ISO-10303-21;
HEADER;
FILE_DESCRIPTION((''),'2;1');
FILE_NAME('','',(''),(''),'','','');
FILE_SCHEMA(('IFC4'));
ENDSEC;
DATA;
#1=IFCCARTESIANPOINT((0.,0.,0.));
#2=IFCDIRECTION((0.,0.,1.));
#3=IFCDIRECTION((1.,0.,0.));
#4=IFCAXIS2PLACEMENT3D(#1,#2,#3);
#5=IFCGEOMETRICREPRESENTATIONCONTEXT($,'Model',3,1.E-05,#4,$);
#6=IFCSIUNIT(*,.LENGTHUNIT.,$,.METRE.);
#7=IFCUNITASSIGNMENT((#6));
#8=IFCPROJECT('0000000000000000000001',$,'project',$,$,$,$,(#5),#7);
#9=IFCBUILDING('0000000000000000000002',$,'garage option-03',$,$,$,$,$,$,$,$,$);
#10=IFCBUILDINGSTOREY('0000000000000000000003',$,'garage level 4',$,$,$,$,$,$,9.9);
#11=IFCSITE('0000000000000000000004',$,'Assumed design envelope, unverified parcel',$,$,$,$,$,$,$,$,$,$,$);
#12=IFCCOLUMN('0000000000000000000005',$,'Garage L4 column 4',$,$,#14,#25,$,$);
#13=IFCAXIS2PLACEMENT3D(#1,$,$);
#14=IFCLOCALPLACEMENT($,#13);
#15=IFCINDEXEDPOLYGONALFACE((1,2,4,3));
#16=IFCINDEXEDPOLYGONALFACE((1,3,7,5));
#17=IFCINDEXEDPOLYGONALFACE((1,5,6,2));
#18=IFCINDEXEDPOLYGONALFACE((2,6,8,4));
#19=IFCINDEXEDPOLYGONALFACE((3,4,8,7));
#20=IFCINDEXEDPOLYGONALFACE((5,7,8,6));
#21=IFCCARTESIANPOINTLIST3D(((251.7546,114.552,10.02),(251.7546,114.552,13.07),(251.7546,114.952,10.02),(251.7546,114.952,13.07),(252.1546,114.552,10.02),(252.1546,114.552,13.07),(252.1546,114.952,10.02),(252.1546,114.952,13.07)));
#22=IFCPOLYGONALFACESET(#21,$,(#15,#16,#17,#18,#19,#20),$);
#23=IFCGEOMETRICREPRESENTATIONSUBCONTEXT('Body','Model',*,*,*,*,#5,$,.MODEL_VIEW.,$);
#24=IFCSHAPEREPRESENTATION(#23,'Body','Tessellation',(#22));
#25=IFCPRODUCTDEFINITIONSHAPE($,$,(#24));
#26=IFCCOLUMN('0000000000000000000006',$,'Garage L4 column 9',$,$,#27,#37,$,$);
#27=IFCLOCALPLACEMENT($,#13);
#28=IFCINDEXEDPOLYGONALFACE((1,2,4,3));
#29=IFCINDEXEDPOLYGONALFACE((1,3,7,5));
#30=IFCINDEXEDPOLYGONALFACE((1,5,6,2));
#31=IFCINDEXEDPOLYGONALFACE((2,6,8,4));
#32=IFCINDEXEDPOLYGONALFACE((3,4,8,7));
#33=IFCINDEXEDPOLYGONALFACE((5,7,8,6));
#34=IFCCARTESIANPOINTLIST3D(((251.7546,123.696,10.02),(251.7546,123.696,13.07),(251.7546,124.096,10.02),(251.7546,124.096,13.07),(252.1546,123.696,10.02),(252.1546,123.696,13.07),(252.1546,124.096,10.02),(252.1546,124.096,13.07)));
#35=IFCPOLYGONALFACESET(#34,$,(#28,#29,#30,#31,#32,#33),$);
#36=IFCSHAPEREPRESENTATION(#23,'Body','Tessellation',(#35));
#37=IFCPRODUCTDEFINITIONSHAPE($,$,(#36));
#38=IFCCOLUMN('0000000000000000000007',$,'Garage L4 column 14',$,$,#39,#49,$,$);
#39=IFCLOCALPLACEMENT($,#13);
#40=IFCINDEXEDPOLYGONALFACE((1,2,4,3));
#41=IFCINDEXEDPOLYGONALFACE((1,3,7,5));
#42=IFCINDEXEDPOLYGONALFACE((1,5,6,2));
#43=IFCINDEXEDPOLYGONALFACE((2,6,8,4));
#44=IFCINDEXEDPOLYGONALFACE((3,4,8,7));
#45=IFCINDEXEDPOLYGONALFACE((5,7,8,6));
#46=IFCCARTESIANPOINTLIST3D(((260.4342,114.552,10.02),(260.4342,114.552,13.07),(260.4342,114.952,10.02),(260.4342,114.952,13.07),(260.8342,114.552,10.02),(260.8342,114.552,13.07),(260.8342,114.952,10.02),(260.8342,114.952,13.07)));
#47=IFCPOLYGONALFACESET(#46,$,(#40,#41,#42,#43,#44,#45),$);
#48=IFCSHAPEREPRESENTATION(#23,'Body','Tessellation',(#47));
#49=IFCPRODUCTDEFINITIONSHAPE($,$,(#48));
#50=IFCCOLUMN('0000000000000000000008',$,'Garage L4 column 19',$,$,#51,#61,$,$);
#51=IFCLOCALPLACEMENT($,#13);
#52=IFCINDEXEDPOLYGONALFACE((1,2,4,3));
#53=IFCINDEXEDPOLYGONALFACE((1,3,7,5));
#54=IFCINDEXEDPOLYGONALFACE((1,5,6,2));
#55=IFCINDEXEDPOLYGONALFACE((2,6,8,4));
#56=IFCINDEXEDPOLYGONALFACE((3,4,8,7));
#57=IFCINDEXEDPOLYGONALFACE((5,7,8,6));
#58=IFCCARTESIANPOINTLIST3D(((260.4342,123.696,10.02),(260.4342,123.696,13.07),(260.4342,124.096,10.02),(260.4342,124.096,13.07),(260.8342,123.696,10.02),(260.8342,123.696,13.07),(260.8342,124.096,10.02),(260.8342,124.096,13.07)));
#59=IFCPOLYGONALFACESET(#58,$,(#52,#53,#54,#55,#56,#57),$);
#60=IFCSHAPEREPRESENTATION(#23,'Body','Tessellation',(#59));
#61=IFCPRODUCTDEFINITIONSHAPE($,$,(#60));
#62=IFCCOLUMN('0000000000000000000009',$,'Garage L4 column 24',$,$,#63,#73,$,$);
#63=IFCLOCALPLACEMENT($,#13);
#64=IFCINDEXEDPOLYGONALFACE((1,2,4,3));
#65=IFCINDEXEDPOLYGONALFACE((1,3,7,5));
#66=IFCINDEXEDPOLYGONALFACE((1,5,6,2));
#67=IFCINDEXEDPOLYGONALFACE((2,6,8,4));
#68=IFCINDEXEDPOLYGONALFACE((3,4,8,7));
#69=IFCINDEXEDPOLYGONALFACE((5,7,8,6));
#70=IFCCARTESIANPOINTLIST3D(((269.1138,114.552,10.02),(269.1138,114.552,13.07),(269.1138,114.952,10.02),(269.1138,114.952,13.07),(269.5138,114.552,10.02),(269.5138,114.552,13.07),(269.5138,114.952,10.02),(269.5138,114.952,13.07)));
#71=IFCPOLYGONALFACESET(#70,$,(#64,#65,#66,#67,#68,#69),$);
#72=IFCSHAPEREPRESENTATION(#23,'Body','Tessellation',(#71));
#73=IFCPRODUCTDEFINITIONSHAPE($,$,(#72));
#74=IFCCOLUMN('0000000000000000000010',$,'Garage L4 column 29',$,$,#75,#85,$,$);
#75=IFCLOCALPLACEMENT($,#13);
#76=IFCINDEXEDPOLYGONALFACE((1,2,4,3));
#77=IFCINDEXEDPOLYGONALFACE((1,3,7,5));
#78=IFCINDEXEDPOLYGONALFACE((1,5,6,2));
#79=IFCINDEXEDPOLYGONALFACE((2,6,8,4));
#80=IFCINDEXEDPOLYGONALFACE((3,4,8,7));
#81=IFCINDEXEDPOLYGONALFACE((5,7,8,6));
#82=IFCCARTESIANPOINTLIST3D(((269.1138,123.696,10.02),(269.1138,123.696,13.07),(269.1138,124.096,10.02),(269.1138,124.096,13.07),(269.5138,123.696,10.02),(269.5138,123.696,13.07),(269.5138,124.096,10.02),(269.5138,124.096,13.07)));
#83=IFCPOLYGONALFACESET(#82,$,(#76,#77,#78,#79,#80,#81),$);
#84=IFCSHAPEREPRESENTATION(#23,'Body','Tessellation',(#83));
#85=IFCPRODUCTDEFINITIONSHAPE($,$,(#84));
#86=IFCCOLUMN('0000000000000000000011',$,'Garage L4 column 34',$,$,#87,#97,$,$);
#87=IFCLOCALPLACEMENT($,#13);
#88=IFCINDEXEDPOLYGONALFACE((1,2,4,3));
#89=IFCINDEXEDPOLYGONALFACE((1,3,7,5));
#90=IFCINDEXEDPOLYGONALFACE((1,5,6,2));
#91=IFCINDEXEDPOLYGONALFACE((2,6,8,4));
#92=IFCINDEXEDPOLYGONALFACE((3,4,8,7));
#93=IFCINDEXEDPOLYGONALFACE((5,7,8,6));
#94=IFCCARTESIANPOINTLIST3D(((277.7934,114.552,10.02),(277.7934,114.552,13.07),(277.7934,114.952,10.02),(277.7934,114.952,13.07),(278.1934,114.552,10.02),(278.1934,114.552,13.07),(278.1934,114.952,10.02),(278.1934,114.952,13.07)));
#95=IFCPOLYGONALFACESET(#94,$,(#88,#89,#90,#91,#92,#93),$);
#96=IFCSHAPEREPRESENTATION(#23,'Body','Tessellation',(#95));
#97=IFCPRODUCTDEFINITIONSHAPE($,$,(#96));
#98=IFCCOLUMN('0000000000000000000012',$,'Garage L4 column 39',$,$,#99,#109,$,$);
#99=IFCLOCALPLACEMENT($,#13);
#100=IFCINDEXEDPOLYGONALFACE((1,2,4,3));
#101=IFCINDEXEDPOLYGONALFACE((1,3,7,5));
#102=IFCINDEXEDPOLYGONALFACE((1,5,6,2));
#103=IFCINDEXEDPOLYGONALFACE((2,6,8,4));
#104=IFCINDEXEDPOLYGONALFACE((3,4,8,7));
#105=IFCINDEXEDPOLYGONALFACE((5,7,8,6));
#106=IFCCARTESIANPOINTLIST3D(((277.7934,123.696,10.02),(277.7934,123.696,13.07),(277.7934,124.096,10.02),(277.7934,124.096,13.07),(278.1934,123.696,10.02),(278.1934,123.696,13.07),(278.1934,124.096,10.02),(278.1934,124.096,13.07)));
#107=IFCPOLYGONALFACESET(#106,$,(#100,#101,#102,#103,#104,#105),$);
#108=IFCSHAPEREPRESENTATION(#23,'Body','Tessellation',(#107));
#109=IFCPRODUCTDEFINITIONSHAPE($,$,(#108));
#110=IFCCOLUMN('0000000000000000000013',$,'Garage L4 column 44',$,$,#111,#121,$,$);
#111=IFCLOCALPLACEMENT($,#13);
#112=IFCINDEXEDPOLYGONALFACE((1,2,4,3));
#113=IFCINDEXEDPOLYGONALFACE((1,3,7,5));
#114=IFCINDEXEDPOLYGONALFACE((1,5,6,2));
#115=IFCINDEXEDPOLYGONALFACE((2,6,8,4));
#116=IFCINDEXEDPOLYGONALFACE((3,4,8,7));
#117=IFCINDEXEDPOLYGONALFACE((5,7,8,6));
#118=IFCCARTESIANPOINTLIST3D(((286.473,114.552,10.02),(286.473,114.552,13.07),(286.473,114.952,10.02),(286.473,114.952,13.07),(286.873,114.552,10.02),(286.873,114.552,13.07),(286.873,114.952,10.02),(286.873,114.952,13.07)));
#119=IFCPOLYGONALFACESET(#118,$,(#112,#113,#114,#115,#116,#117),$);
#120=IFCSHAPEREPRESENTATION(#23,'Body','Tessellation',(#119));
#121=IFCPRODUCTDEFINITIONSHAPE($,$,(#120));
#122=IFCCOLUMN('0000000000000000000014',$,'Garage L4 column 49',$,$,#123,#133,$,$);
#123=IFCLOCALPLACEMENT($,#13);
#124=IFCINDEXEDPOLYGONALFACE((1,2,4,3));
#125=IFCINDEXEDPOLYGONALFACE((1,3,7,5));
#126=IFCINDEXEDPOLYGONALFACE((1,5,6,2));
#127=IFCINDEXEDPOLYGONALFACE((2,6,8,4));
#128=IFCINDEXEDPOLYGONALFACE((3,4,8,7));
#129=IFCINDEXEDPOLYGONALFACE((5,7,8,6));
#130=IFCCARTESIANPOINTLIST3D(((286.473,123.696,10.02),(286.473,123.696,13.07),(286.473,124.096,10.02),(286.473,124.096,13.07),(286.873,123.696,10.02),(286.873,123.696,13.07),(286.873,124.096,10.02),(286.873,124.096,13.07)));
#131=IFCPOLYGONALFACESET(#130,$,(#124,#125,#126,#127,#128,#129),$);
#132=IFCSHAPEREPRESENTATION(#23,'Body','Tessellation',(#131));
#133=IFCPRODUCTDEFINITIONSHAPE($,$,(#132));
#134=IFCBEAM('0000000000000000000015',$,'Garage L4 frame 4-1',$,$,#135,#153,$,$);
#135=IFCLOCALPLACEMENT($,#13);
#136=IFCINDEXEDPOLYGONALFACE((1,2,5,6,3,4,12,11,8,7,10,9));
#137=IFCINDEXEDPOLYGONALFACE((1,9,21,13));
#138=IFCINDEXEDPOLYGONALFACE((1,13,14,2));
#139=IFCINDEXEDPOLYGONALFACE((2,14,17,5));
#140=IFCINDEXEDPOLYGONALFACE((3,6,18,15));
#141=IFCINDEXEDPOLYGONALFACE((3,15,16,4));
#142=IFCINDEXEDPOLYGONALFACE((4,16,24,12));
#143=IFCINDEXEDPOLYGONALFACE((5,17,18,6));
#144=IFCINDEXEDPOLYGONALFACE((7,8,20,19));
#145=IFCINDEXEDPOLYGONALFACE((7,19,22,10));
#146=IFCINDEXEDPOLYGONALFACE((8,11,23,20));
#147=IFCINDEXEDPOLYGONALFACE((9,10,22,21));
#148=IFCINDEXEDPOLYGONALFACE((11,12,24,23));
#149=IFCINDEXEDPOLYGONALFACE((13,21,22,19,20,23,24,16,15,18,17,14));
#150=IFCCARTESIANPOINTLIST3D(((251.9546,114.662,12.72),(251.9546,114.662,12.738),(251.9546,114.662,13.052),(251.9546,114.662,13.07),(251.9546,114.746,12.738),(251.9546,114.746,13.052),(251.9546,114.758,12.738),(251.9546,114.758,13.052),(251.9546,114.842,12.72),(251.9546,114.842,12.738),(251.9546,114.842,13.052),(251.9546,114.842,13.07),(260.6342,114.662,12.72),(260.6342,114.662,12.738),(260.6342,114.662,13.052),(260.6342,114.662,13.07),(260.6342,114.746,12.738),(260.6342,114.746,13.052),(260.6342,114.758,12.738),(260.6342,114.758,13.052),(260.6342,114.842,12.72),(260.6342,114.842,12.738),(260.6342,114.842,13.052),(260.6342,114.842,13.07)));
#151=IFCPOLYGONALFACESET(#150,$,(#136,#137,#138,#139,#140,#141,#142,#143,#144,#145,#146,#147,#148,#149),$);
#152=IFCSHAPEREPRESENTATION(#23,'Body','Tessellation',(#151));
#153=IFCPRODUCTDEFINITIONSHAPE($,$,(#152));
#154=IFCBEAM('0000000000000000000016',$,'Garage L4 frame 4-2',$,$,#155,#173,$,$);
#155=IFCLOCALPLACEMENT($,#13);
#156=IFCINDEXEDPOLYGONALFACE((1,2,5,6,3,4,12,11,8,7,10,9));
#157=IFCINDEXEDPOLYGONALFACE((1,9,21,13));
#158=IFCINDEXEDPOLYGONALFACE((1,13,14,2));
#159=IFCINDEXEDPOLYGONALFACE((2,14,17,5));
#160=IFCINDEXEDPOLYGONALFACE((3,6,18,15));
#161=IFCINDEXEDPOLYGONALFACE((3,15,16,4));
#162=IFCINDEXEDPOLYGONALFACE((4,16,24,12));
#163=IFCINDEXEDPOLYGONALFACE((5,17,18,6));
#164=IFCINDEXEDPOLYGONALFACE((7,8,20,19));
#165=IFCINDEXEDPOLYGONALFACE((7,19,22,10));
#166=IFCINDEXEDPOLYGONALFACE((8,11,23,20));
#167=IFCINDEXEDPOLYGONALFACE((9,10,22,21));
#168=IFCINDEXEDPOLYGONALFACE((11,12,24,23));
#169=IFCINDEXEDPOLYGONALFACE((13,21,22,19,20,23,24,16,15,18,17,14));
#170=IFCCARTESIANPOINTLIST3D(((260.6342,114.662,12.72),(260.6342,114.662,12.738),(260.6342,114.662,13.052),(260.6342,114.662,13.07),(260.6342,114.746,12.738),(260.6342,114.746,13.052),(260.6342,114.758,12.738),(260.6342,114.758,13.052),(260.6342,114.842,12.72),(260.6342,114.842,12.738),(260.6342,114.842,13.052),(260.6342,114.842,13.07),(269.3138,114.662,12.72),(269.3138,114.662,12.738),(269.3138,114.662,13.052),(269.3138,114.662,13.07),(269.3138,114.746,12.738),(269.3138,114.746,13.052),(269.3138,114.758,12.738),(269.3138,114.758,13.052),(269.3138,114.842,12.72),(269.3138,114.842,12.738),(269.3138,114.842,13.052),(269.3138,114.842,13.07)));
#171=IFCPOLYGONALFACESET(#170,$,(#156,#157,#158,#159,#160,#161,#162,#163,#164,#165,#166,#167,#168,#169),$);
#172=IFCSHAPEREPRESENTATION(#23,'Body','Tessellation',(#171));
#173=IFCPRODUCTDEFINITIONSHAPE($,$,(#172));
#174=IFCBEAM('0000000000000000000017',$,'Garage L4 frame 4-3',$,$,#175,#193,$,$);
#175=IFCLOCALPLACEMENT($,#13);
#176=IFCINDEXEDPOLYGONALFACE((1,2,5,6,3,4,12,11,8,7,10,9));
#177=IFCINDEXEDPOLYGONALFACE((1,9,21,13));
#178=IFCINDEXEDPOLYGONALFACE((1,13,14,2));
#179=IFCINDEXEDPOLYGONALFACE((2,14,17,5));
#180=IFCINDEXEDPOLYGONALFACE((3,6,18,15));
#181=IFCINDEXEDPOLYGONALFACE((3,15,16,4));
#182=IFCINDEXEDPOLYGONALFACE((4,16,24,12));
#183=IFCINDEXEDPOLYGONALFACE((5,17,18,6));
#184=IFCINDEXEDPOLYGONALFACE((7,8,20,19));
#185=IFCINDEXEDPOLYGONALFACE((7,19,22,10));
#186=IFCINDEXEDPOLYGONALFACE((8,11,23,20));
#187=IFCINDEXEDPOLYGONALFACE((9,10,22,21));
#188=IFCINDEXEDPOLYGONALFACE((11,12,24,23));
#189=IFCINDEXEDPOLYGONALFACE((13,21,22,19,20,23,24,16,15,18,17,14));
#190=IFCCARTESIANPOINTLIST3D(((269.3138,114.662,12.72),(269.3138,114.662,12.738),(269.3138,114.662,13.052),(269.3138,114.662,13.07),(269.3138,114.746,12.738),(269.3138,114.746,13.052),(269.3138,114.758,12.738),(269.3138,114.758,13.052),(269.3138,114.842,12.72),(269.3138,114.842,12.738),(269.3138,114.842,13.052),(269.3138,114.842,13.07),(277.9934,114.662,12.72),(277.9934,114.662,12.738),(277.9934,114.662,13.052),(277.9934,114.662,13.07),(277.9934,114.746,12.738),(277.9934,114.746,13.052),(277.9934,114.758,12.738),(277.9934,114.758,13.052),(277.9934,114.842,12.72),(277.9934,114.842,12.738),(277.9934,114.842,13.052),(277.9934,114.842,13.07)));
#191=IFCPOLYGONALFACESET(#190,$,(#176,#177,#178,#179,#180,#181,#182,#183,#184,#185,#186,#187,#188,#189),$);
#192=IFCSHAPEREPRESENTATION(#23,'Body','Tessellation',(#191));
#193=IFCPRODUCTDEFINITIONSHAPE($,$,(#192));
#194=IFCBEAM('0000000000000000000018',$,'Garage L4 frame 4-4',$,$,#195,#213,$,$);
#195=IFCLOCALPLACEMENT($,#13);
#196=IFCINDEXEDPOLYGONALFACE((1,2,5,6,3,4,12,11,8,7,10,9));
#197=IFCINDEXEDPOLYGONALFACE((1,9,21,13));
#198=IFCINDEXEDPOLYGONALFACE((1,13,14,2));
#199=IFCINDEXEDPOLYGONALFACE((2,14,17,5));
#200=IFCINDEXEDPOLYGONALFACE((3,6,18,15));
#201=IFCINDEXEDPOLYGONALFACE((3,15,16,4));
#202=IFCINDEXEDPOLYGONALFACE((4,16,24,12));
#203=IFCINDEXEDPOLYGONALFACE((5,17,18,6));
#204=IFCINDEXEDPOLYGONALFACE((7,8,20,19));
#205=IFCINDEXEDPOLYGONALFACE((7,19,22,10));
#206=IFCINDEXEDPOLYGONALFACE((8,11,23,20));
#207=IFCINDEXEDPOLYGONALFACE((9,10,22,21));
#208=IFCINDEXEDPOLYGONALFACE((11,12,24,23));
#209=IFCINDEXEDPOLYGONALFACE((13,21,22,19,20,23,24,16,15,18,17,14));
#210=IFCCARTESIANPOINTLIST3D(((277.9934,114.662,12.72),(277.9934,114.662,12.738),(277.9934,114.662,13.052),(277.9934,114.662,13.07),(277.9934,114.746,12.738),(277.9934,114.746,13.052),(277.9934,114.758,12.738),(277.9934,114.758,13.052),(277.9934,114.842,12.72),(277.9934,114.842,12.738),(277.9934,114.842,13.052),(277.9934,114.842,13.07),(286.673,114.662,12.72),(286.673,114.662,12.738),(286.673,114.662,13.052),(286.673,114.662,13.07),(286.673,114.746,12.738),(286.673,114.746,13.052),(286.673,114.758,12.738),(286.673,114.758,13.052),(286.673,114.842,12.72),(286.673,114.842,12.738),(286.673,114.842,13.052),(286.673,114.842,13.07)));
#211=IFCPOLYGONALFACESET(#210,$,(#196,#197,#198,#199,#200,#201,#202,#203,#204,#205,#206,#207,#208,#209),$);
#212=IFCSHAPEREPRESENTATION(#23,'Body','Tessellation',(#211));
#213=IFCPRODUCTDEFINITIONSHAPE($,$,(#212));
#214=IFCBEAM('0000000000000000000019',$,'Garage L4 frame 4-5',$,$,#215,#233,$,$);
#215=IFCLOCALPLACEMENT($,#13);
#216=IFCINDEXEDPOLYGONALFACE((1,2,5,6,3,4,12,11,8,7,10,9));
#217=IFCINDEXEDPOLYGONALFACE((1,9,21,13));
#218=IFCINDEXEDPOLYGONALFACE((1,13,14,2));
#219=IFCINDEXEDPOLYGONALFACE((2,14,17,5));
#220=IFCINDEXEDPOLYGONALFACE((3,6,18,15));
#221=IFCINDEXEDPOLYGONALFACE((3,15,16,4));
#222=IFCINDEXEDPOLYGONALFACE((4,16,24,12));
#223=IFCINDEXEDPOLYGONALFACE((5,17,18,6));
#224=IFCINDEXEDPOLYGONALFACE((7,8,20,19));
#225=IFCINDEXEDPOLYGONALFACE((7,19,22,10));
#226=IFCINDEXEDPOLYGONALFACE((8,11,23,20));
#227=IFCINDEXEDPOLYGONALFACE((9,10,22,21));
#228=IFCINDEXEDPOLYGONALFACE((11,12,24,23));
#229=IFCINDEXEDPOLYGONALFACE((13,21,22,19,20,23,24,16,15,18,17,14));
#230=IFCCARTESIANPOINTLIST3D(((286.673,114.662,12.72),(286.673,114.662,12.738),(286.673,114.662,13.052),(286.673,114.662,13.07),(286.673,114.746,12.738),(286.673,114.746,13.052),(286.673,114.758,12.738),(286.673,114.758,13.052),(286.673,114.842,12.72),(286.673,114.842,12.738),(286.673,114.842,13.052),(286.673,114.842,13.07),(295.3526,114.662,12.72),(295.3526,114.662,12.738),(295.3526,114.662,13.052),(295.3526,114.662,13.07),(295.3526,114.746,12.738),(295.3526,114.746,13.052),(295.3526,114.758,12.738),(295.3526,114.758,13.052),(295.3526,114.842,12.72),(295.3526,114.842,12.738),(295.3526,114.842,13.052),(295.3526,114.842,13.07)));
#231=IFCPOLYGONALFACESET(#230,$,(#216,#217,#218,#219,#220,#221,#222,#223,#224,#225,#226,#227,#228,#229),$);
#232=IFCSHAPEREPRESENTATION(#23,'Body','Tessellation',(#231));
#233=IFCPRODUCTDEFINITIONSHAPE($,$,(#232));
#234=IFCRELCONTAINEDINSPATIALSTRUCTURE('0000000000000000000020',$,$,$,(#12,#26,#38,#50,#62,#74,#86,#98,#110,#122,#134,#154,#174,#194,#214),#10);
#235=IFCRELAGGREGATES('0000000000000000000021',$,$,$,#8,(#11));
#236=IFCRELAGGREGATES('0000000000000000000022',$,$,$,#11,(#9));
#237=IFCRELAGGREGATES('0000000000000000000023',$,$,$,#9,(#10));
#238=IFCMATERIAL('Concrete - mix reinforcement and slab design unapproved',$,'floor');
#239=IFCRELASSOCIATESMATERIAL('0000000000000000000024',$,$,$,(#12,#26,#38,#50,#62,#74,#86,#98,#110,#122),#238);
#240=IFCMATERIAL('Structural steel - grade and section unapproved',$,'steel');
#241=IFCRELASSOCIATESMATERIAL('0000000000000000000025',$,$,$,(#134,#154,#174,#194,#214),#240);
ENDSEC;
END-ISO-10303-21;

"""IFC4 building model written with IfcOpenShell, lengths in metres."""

from ifc_helpers import new_model, si_unit, frame, origin_with_axes, place, context, subcontext, project, spatial, rectangle, i_section, extrude, material, element, save


model = new_model("IFC4")

# Units and contexts
model_context = context("Model", 3, precision=1e-05, world=origin_with_axes())
body_context = subcontext(model_context, "Body", "Model", "MODEL_VIEW")
ifc_project = project(units=[si_unit("LENGTHUNIT", "METRE")], contexts=[model_context])

# Site, building, storey
site = spatial("IfcSite", under=ifc_project, Name="Assumed design envelope, unverified parcel")
building = spatial("IfcBuilding", under=site, Name="garage option-03")
storey = spatial("IfcBuildingStorey", under=building, Name="garage level 4", Elevation=9.9)

# Columns
ifc_material_1 = material(Name="Concrete - mix reinforcement and slab design unapproved", Category="floor")
for number, where, z_axis, x_axis, name in (
    (1, (251.9546, 114.752, 10.02), (0.0, 0.0, 1.0), (1.0, 0.0, 0.0), "Garage L4 column 4"),
    (2, (251.9546, 123.896, 10.02), (0.0, 0.0, 1.0), (1.0, 0.0, 0.0), "Garage L4 column 9"),
    (3, (260.6342, 114.752, 10.02), (0.0, 0.0, 1.0), (1.0, 0.0, 0.0), "Garage L4 column 14"),
    (4, (260.6342, 123.896, 10.02), (0.0, 0.0, 1.0), (1.0, 0.0, 0.0), "Garage L4 column 19"),
    (5, (269.3138, 114.752, 10.02), (0.0, 0.0, 1.0), (1.0, 0.0, 0.0), "Garage L4 column 24"),
    (6, (269.3138, 123.896, 10.02), (0.0, 0.0, 1.0), (1.0, 0.0, 0.0), "Garage L4 column 29"),
    (7, (277.9934, 114.752, 10.02), (0.0, 0.0, 1.0), (1.0, 0.0, 0.0), "Garage L4 column 34"),
    (8, (277.9934, 123.896, 10.02), (0.0, 0.0, 1.0), (1.0, 0.0, 0.0), "Garage L4 column 39"),
    (9, (286.673, 114.752, 10.02), (0.0, 0.0, 1.0), (1.0, 0.0, 0.0), "Garage L4 column 44"),
    (10, (286.673, 123.896, 10.02), (0.0, 0.0, 1.0), (1.0, 0.0, 0.0), "Garage L4 column 49"),
):
    element("IfcColumn", number, at=place(None, frame(where, z_axis=z_axis, x_axis=x_axis)), inside=storey, material=ifc_material_1, Name=name, context=body_context, shape_type="SweptSolid", body=[
        extrude(rectangle(XDim=0.4, YDim=0.4), origin_with_axes(), (0.0, 0.0, 1.0), 3.05),
    ])

# Beams
ifc_material_2 = material(Name="Structural steel - grade and section unapproved", Category="steel")
beam_1_placement = place(None, frame((251.9546, 114.752, 12.895), z_axis=(1.0, 0.0, 0.0), x_axis=(0.0, 1.0, 0.0)))
element("IfcBeam", 11, at=beam_1_placement, inside=storey, material=ifc_material_2, Name="Garage L4 frame 4-1", context=body_context, shape_type="SweptSolid", body=[
    extrude(i_section(OverallWidth=0.18, OverallDepth=0.35, WebThickness=0.012, FlangeThickness=0.018, FilletRadius=0.0), origin_with_axes(), (0.0, 0.0, 1.0), 8.6796),
])
beam_2_placement = place(None, frame((260.6342, 114.752, 12.895), z_axis=(1.0, 0.0, 0.0), x_axis=(0.0, 1.0, 0.0)))
element("IfcBeam", 12, at=beam_2_placement, inside=storey, material=ifc_material_2, Name="Garage L4 frame 4-2", context=body_context, shape_type="SweptSolid", body=[
    extrude(i_section(OverallWidth=0.18, OverallDepth=0.35, WebThickness=0.012, FlangeThickness=0.018, FilletRadius=0.0), origin_with_axes(), (0.0, 0.0, 1.0), 8.6796),
])
for number, where, z_axis, x_axis, name in (
    (13, (269.3138, 114.752, 12.895), (1.0, 0.0, 0.0), (0.0, 1.0, 0.0), "Garage L4 frame 4-3"),
    (14, (277.9934, 114.752, 12.895), (1.0, 0.0, 0.0), (0.0, 1.0, 0.0), "Garage L4 frame 4-4"),
    (15, (286.673, 114.752, 12.895), (1.0, 0.0, 0.0), (0.0, 1.0, 0.0), "Garage L4 frame 4-5"),
):
    element("IfcBeam", number, at=place(None, frame(where, z_axis=z_axis, x_axis=x_axis)), inside=storey, material=ifc_material_2, Name=name, context=body_context, shape_type="SweptSolid", body=[
        extrude(i_section(OverallWidth=0.18, OverallDepth=0.35, WebThickness=0.012, FlangeThickness=0.018, FilletRadius=0.0), origin_with_axes(), (0.0, 0.0, 1.0), 8.6796),
    ])

save(model, "model.ifc")
